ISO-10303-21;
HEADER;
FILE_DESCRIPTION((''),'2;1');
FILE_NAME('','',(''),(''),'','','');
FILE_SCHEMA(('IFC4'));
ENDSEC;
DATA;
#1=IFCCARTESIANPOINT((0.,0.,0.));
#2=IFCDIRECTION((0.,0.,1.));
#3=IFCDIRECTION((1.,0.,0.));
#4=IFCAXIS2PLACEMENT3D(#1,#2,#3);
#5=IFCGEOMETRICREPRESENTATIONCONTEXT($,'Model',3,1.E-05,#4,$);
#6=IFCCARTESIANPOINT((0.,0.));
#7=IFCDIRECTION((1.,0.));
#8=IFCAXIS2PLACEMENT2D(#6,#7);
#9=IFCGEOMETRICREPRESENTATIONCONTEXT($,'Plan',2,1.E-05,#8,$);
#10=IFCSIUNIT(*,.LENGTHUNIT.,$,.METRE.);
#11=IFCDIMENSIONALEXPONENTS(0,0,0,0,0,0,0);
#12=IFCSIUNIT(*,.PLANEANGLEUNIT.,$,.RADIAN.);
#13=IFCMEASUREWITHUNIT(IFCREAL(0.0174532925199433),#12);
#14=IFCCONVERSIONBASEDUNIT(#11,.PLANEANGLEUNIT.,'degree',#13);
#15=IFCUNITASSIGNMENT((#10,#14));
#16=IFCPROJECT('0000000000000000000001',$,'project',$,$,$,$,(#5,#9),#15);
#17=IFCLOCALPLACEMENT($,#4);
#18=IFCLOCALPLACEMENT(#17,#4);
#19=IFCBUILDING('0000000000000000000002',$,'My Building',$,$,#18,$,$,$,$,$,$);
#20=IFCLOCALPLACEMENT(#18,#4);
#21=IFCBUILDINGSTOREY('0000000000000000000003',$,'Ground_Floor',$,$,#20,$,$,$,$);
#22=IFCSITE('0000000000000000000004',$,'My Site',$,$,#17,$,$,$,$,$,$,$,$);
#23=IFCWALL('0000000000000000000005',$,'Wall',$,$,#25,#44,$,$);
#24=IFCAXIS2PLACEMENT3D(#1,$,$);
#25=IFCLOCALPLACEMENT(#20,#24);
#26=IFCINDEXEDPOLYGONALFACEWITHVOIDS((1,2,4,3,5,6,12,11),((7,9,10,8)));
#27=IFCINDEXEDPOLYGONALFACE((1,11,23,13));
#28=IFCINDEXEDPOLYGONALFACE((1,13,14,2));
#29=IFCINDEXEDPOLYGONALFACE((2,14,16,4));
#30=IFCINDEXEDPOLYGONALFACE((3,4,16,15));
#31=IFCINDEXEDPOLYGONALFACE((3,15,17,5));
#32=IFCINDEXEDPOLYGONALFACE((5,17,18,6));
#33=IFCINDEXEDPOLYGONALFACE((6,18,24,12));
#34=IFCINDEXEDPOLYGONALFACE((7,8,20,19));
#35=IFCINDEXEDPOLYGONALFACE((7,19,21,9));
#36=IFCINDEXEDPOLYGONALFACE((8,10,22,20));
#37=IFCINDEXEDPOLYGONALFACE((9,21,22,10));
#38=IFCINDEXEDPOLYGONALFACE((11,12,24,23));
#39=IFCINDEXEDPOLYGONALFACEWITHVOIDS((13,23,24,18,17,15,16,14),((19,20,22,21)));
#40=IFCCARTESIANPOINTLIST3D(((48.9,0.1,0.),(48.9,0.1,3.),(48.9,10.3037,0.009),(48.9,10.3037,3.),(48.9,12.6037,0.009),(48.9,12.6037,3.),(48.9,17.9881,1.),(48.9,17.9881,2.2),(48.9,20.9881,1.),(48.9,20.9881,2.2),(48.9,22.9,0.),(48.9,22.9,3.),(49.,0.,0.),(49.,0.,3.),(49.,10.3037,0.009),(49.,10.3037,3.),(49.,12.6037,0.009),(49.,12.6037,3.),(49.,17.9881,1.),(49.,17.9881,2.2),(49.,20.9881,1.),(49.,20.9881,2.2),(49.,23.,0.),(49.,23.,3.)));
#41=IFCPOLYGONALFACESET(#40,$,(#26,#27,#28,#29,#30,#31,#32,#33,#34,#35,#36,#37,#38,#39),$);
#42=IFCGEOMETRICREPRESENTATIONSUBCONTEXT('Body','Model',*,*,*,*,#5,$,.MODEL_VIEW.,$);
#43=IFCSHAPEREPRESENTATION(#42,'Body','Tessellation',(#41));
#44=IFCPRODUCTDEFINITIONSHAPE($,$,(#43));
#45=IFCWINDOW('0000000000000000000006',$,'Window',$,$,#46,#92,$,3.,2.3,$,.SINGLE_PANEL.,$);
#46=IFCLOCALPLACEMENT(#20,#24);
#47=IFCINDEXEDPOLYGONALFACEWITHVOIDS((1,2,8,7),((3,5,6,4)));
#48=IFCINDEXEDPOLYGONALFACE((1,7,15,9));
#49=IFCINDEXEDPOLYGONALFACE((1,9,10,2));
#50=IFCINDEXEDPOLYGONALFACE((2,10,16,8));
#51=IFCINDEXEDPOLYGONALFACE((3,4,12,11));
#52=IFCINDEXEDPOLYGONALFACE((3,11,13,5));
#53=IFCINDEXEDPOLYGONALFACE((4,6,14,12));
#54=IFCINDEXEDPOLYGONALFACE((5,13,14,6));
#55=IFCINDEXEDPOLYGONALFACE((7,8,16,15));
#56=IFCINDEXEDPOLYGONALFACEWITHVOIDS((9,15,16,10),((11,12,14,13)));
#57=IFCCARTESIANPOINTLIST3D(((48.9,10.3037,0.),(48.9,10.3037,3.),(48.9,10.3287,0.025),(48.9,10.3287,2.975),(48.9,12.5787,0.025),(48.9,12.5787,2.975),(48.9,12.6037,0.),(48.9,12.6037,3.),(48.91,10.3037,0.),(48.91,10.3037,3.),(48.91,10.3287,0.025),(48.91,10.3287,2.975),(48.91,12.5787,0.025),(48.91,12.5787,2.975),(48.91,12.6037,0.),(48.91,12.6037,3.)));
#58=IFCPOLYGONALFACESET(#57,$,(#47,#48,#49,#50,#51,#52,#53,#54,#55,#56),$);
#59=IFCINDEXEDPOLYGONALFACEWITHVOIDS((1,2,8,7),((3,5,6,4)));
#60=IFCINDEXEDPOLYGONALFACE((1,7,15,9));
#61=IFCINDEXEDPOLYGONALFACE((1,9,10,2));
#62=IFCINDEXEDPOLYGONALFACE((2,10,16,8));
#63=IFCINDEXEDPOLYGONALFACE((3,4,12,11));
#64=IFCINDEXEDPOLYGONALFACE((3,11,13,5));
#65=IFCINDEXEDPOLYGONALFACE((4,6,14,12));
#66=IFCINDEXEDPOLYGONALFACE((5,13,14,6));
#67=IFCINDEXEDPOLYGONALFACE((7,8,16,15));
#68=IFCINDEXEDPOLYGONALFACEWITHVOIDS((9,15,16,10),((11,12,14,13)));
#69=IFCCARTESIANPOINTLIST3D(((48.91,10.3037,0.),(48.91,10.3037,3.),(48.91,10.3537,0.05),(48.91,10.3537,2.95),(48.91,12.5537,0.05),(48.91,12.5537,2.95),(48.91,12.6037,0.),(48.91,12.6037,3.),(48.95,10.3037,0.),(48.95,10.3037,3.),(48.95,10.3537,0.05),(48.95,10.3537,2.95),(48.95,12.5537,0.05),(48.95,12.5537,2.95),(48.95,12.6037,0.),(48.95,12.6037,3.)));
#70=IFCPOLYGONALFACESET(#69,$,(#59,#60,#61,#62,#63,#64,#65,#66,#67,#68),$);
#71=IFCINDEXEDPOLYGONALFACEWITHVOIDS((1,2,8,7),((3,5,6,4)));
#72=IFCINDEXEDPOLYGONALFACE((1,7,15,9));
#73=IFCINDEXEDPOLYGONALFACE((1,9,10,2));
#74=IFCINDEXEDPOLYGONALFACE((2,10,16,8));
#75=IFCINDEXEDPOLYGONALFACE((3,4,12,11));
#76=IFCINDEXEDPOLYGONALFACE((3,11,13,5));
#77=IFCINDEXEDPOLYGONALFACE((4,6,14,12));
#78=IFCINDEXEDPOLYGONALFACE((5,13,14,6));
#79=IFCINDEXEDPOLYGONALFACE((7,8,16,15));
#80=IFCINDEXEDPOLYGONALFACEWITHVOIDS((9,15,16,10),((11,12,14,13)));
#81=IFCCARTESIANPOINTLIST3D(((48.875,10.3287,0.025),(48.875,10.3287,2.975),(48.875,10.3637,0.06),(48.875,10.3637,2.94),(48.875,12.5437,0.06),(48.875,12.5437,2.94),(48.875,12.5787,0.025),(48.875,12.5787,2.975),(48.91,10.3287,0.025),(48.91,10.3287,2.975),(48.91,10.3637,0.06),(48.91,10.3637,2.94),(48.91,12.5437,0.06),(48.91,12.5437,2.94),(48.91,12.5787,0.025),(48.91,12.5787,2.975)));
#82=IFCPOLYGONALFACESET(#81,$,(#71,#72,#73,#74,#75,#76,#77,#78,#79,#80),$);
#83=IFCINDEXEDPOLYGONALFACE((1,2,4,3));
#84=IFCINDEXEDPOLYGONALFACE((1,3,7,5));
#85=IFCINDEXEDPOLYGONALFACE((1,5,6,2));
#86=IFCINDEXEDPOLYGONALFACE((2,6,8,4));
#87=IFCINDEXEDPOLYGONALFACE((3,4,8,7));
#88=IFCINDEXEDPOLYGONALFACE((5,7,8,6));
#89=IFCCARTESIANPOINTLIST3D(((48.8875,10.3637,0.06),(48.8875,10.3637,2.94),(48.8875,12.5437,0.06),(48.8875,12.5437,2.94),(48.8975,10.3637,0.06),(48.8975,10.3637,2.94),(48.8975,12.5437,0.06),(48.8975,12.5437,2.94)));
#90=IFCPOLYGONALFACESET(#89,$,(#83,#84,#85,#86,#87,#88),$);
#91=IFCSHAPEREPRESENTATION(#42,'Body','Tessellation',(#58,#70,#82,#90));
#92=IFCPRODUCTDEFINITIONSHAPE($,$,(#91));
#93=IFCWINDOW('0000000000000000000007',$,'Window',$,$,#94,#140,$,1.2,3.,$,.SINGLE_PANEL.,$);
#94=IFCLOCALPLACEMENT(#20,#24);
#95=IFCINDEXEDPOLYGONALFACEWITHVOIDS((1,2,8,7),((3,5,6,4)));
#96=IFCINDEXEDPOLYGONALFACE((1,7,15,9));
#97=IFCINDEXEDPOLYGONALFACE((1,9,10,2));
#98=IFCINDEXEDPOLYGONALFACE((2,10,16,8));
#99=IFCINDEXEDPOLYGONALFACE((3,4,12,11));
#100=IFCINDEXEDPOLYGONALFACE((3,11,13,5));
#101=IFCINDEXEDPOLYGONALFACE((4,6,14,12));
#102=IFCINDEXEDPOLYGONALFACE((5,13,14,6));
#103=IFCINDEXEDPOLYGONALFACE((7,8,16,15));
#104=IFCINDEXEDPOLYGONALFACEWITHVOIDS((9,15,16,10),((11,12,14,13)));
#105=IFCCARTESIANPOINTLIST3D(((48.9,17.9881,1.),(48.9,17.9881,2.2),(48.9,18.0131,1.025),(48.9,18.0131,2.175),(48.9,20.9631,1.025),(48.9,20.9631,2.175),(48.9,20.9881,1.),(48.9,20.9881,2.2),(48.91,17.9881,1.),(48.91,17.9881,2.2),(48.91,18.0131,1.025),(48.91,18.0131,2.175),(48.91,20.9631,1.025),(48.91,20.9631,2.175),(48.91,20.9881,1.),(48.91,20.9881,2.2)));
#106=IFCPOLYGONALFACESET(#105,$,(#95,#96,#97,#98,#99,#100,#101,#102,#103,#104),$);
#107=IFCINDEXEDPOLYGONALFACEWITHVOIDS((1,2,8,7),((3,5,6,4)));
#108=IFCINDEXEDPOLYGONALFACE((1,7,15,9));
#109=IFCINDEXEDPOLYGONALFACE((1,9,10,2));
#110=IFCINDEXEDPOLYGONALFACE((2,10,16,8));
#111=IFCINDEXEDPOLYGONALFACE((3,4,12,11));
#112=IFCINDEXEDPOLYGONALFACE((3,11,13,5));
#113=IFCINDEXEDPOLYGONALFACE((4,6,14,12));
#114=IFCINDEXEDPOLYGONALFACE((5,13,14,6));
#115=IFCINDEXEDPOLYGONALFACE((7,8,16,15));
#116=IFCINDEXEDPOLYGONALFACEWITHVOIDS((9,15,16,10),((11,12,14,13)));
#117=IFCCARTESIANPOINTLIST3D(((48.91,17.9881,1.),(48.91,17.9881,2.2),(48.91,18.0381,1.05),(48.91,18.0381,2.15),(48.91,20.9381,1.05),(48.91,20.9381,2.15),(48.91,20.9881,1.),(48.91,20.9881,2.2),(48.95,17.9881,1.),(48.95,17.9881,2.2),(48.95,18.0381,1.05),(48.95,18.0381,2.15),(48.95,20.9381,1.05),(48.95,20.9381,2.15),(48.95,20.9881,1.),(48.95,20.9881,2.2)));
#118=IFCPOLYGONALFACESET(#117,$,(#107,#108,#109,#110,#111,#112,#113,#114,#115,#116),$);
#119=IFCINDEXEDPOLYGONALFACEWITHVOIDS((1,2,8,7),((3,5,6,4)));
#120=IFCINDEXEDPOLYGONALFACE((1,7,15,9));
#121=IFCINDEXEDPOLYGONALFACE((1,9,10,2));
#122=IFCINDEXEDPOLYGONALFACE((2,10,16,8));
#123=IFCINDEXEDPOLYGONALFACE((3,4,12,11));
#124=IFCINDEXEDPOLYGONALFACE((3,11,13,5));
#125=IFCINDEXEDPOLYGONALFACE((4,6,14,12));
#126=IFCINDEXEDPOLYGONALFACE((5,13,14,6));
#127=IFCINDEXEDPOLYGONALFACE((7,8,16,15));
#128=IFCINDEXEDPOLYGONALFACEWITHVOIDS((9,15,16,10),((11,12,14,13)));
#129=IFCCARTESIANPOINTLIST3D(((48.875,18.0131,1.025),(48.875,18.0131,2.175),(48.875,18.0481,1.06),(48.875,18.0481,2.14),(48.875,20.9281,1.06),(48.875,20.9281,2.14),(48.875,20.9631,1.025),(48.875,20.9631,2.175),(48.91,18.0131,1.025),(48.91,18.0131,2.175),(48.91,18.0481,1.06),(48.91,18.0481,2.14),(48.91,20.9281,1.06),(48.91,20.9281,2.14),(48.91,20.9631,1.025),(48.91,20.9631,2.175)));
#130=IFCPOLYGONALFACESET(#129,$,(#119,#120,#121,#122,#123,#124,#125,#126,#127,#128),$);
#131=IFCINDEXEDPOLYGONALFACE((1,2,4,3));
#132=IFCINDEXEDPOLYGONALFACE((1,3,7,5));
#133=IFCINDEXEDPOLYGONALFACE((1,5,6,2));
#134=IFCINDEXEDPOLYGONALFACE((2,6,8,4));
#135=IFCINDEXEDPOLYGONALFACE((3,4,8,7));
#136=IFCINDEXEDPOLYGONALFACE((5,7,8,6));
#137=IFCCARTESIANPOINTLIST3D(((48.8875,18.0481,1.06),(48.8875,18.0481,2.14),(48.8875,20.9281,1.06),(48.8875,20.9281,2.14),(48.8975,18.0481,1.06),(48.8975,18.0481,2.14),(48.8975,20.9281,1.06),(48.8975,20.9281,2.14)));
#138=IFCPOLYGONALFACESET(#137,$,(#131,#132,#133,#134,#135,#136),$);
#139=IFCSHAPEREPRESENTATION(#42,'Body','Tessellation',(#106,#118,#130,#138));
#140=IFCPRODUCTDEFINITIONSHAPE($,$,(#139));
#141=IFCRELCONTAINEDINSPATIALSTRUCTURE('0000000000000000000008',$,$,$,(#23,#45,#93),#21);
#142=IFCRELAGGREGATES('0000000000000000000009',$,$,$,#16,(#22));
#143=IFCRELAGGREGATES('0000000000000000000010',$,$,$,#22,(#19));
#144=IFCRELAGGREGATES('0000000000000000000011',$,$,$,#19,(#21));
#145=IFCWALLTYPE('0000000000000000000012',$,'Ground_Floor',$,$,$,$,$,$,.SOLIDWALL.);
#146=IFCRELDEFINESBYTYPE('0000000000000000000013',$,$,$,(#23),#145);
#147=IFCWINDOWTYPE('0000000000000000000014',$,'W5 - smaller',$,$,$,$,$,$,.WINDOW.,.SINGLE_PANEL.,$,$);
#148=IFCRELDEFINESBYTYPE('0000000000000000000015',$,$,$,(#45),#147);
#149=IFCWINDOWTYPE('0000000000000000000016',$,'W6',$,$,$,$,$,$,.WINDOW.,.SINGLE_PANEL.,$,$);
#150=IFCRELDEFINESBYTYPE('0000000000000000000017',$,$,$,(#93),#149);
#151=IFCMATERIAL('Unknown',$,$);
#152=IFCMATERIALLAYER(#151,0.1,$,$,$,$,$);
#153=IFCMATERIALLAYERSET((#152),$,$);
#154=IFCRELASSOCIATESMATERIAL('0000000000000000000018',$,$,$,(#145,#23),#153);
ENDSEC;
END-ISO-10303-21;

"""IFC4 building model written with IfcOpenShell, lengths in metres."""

from ifc_helpers import new_model, entity, si_unit, converted_unit, frame, origin_with_axes, origin_2d_with_axis, place, context, subcontext, project, spatial, line, indexed_curve, outline, extrude, shape, source, transform, mapped, material, layer, layer_set, layer_usage, type_object, type_shapes, element, fill, save


model = new_model("IFC4")

# Units and contexts
model_context = context("Model", 3, precision=1e-05, world=origin_with_axes())
plan_context = context("Plan", 2, precision=1e-05, world=origin_2d_with_axis())
body_context_1 = subcontext(model_context, "Body", "Model", "MODEL_VIEW")
body_context_2 = subcontext(plan_context, "Body", "Plan", "PLAN_VIEW")
ifc_project = project(units=[si_unit("LENGTHUNIT", "METRE"), converted_unit("PLANEANGLEUNIT", "degree", entity("IfcReal", 0.0174532925199433), si_unit("PLANEANGLEUNIT", "RADIAN"), dimensions=[0, 0, 0, 0, 0, 0, 0])], contexts=[model_context, plan_context])

# Site, building, storey
site_placement = place(None, origin_with_axes())
site = spatial("IfcSite", under=ifc_project, at=site_placement, Name="My Site")
building_placement = place(site_placement, origin_with_axes())
building = spatial("IfcBuilding", under=site, at=building_placement, Name="My Building")
storey_placement = place(building_placement, origin_with_axes())
storey = spatial("IfcBuildingStorey", under=building, at=storey_placement, Name="Ground_Floor")

# Shared definitions
ifc_material = material(Name="Unknown")

# Wall, openings, windows
ifc_layer = layer(ifc_material, 0.1)
ifc_layer_set = layer_set([ifc_layer])
ifc_layer_usage_1 = layer_usage(ifc_layer_set, "AXIS2", "POSITIVE", 0.0)
wall_type = type_object("IfcWallType", Name="Ground_Floor", PredefinedType="SOLIDWALL", material=ifc_layer_set)
wall_1_placement = place(storey_placement, frame((49.0, 0.0, 0.0), z_axis=(0.0, 0.0, 1.0), x_axis=(0.0, 1.0, 0.0)))
wall_1 = element("IfcWall", 1, at=wall_1_placement, inside=storey, type_object=wall_type, material=ifc_layer_usage_1, Name="Wall", context=body_context_1, shape_type="SweptSolid", body=[
    extrude(outline(indexed_curve([(0.0, 0.0), (0.1, 0.1), (22.9, 0.1), (23.0, 0.0)], segments=[line(1, 2, 3, 4, 1)])), origin_with_axes(), (0.0, 0.0, 1.0), 3.0),
])
shared_shape_1 = source(origin_with_axes(), body_context_1, "Body", "SweptSolid", [
    extrude(outline(indexed_curve([(0.0, 0.0), (2.3, 0.0), (2.3, 3.0), (0.0, 3.0)], segments=[line(1, 2, 3, 4, 1)])), frame((0.0, -0.6, 0.0), z_axis=(0.0, -1.0, 0.0), x_axis=(1.0, 0.0, 0.0)), (0.0, 0.0, -1.0), 1.2),
])
opening_1_placement = place(wall_1_placement, frame((10.3037, 0.0, 0.009), z_axis=(0.0, 0.0, 1.0), x_axis=(1.0, 0.0, 0.0)))
opening_1 = element("IfcOpeningElement", 2, at=opening_1_placement, cuts=wall_1, PredefinedType="OPENING", context=body_context_1, shape_type="MappedRepresentation", body=[
    mapped(shared_shape_1, transform((0.0, 0.0, 0.0), x_axis=(1.0, 0.0, 0.0), y_axis=(0.0, 1.0, 0.0), z_axis=(0.0, 0.0, 1.0), scale=1.0)),
])
shared_shape_2 = source(origin_with_axes(), body_context_1, "Body", "SweptSolid", [
    extrude(outline(indexed_curve([(0.0, 0.0), (3.0, 0.0), (3.0, 1.2), (0.0, 1.2)], segments=[line(1, 2, 3, 4, 1)])), frame((0.0, -0.6, 0.0), z_axis=(0.0, -1.0, 0.0), x_axis=(1.0, 0.0, 0.0)), (0.0, 0.0, -1.0), 1.2),
])
opening_2_placement = place(wall_1_placement, frame((17.9881, 0.0, 1.0), z_axis=(0.0, 0.0, 1.0), x_axis=(1.0, 0.0, 0.0)))
opening_2 = element("IfcOpeningElement", 3, at=opening_2_placement, cuts=wall_1, PredefinedType="OPENING", context=body_context_1, shape_type="MappedRepresentation", body=[
    mapped(shared_shape_2, transform((0.0, 0.0, 0.0), x_axis=(1.0, 0.0, 0.0), y_axis=(0.0, 1.0, 0.0), z_axis=(0.0, 0.0, 1.0), scale=1.0)),
])
window_type_1 = type_object("IfcWindowType", Name="W5 - smaller", PartitioningType="SINGLE_PANEL", PredefinedType="WINDOW")
shared_shape_3 = source(origin_with_axes(), body_context_1, "Body", "SweptSolid", [
    extrude(outline(indexed_curve([(0.0, 0.0), (2.3, 0.0), (2.3, 3.0), (0.0, 3.0)], segments=[line(1, 2, 3, 4, 1)]), holes=[indexed_curve([(0.025, 0.025), (2.275, 0.025), (2.275, 2.975), (0.025, 2.975)], segments=[line(1, 2, 3, 4, 1)])]), frame((0.0, 0.09, 0.0), z_axis=(0.0, -1.0, 0.0), x_axis=(1.0, 0.0, 0.0)), (0.0, 0.0, -1.0), 0.01),
    extrude(outline(indexed_curve([(0.0, 0.0), (2.3, 0.0), (2.3, 3.0), (0.0, 3.0)], segments=[line(1, 2, 3, 4, 1)]), holes=[indexed_curve([(0.05, 0.05), (2.25, 0.05), (2.25, 2.95), (0.05, 2.95)], segments=[line(1, 2, 3, 4, 1)])]), frame((0.0, 0.05, 0.0), z_axis=(0.0, -1.0, 0.0), x_axis=(1.0, 0.0, 0.0)), (0.0, 0.0, -1.0), 0.04),
    extrude(outline(indexed_curve([(0.0, 0.0), (2.25, 0.0), (2.25, 2.95), (0.0, 2.95)], segments=[line(1, 2, 3, 4, 1)]), holes=[indexed_curve([(0.035, 0.035), (2.215, 0.035), (2.215, 2.915), (0.035, 2.915)], segments=[line(1, 2, 3, 4, 1)])]), frame((0.025, 0.09, 0.025), z_axis=(0.0, -1.0, 0.0), x_axis=(1.0, 0.0, 0.0)), (0.0, 0.0, -1.0), 0.035),
    extrude(outline(indexed_curve([(0.035, 0.035), (2.215, 0.035), (2.215, 2.915), (0.035, 2.915)], segments=[line(1, 2, 3, 4, 1)])), frame((0.025, 0.1025, 0.025), z_axis=(0.0, -1.0, 0.0), x_axis=(1.0, 0.0, 0.0)), (0.0, 0.0, -1.0), 0.01),
])
shared_shape_4 = source(origin_with_axes(), body_context_2, "Body", "Curve2D", [
    entity("IfcIndexedPolyCurve", entity("IfcCartesianPointList2D", [[0.05, 0.05], [2.25, 0.05]])),
    entity("IfcIndexedPolyCurve", entity("IfcCartesianPointList2D", [[0.0, 0.1], [0.025, 0.1], [0.025, 0.09], [0.05, 0.09], [0.05, 0.05], [0.0, 0.05]]), [entity("IfcLineIndex", [1, 2, 3, 4, 5, 6, 1])]),
    entity("IfcIndexedPolyCurve", entity("IfcCartesianPointList2D", [[2.3, 0.1], [2.275, 0.1], [2.275, 0.09], [2.25, 0.09], [2.25, 0.05], [2.3, 0.05]]), [entity("IfcLineIndex", [1, 2, 3, 4, 5, 6, 1])]),
    entity("IfcIndexedPolyCurve", entity("IfcCartesianPointList2D", [[0.025, 0.09], [0.06, 0.09], [0.06, 0.125], [0.025, 0.125]]), [entity("IfcLineIndex", [1, 2, 3, 4, 1])]),
    entity("IfcIndexedPolyCurve", entity("IfcCartesianPointList2D", [[2.275, 0.09], [2.24, 0.09], [2.24, 0.125], [2.275, 0.125]]), [entity("IfcLineIndex", [1, 2, 3, 4, 1])]),
    entity("IfcIndexedPolyCurve", entity("IfcCartesianPointList2D", [[0.06, 0.09], [2.24, 0.09]])),
    entity("IfcIndexedPolyCurve", entity("IfcCartesianPointList2D", [[0.06, 0.125], [2.24, 0.125]])),
    entity("IfcIndexedPolyCurve", entity("IfcCartesianPointList2D", [[0.06, 0.1075], [2.24, 0.1075]])),
])
type_shapes(window_type_1, [shared_shape_3, shared_shape_4])
window_1_placement = place(opening_1_placement, frame((0.0, 0.0, -0.009), z_axis=(0.0, 0.0, 1.0), x_axis=(1.0, 0.0, 0.0)))
window_1 = element("IfcWindow", 4, at=window_1_placement, inside=storey, type_object=window_type_1, Name="Window", OverallHeight=3.0, OverallWidth=2.3, PartitioningType="SINGLE_PANEL", shapes=[
    shape(body_context_1, "Body", "MappedRepresentation", [mapped(shared_shape_3, transform((0.0, 0.0, 0.0), x_axis=(1.0, 0.0, 0.0), y_axis=(0.0, 1.0, 0.0), z_axis=(0.0, 0.0, 1.0), scale=1.0))]),
    shape(body_context_2, "Body", "MappedRepresentation", [mapped(shared_shape_4, transform((0.0, 0.0, 0.0), x_axis=(1.0, 0.0, 0.0), y_axis=(0.0, 1.0, 0.0), z_axis=(0.0, 0.0, 1.0), scale=1.0))]),
])
fill(opening_1, window_1)
window_type_2 = type_object("IfcWindowType", Name="W6", PartitioningType="SINGLE_PANEL", PredefinedType="WINDOW")
shared_shape_5 = source(origin_with_axes(), body_context_1, "Body", "SweptSolid", [
    extrude(outline(indexed_curve([(0.0, 0.0), (3.0, 0.0), (3.0, 1.2), (0.0, 1.2)], segments=[line(1, 2, 3, 4, 1)]), holes=[indexed_curve([(0.025, 0.025), (2.975, 0.025), (2.975, 1.175), (0.025, 1.175)], segments=[line(1, 2, 3, 4, 1)])]), frame((0.0, 0.09, 0.0), z_axis=(0.0, -1.0, 0.0), x_axis=(1.0, 0.0, 0.0)), (0.0, 0.0, -1.0), 0.01),
    extrude(outline(indexed_curve([(0.0, 0.0), (3.0, 0.0), (3.0, 1.2), (0.0, 1.2)], segments=[line(1, 2, 3, 4, 1)]), holes=[indexed_curve([(0.05, 0.05), (2.95, 0.05), (2.95, 1.15), (0.05, 1.15)], segments=[line(1, 2, 3, 4, 1)])]), frame((0.0, 0.05, 0.0), z_axis=(0.0, -1.0, 0.0), x_axis=(1.0, 0.0, 0.0)), (0.0, 0.0, -1.0), 0.04),
    extrude(outline(indexed_curve([(0.0, 0.0), (2.95, 0.0), (2.95, 1.15), (0.0, 1.15)], segments=[line(1, 2, 3, 4, 1)]), holes=[indexed_curve([(0.035, 0.035), (2.915, 0.035), (2.915, 1.115), (0.035, 1.115)], segments=[line(1, 2, 3, 4, 1)])]), frame((0.025, 0.09, 0.025), z_axis=(0.0, -1.0, 0.0), x_axis=(1.0, 0.0, 0.0)), (0.0, 0.0, -1.0), 0.035),
    extrude(outline(indexed_curve([(0.035, 0.035), (2.915, 0.035), (2.915, 1.115), (0.035, 1.115)], segments=[line(1, 2, 3, 4, 1)])), frame((0.025, 0.1025, 0.025), z_axis=(0.0, -1.0, 0.0), x_axis=(1.0, 0.0, 0.0)), (0.0, 0.0, -1.0), 0.01),
])
shared_shape_6 = source(origin_with_axes(), body_context_2, "Body", "Curve2D", [
    entity("IfcIndexedPolyCurve", entity("IfcCartesianPointList2D", [[0.05, 0.05], [2.95, 0.05]])),
    entity("IfcIndexedPolyCurve", entity("IfcCartesianPointList2D", [[0.0, 0.1], [0.025, 0.1], [0.025, 0.09], [0.05, 0.09], [0.05, 0.05], [0.0, 0.05]]), [entity("IfcLineIndex", [1, 2, 3, 4, 5, 6, 1])]),
    entity("IfcIndexedPolyCurve", entity("IfcCartesianPointList2D", [[3.0, 0.1], [2.975, 0.1], [2.975, 0.09], [2.95, 0.09], [2.95, 0.05], [3.0, 0.05]]), [entity("IfcLineIndex", [1, 2, 3, 4, 5, 6, 1])]),
    entity("IfcIndexedPolyCurve", entity("IfcCartesianPointList2D", [[0.025, 0.09], [0.06, 0.09], [0.06, 0.125], [0.025, 0.125]]), [entity("IfcLineIndex", [1, 2, 3, 4, 1])]),
    entity("IfcIndexedPolyCurve", entity("IfcCartesianPointList2D", [[2.975, 0.09], [2.94, 0.09], [2.94, 0.125], [2.975, 0.125]]), [entity("IfcLineIndex", [1, 2, 3, 4, 1])]),
    entity("IfcIndexedPolyCurve", entity("IfcCartesianPointList2D", [[0.06, 0.09], [2.94, 0.09]])),
    entity("IfcIndexedPolyCurve", entity("IfcCartesianPointList2D", [[0.06, 0.125], [2.94, 0.125]])),
    entity("IfcIndexedPolyCurve", entity("IfcCartesianPointList2D", [[0.06, 0.1075], [2.94, 0.1075]])),
])
type_shapes(window_type_2, [shared_shape_5, shared_shape_6])
window_2_placement = place(opening_2_placement, origin_with_axes())
window_2 = element("IfcWindow", 5, at=window_2_placement, inside=storey, type_object=window_type_2, Name="Window", OverallHeight=1.2, OverallWidth=3.0, PartitioningType="SINGLE_PANEL", shapes=[
    shape(body_context_1, "Body", "MappedRepresentation", [mapped(shared_shape_5, transform((0.0, 0.0, 0.0), x_axis=(1.0, 0.0, 0.0), y_axis=(0.0, 1.0, 0.0), z_axis=(0.0, 0.0, 1.0), scale=1.0))]),
    shape(body_context_2, "Body", "MappedRepresentation", [mapped(shared_shape_6, transform((0.0, 0.0, 0.0), x_axis=(1.0, 0.0, 0.0), y_axis=(0.0, 1.0, 0.0), z_axis=(0.0, 0.0, 1.0), scale=1.0))]),
])
fill(opening_2, window_2)

save(model, "model.ifc")
